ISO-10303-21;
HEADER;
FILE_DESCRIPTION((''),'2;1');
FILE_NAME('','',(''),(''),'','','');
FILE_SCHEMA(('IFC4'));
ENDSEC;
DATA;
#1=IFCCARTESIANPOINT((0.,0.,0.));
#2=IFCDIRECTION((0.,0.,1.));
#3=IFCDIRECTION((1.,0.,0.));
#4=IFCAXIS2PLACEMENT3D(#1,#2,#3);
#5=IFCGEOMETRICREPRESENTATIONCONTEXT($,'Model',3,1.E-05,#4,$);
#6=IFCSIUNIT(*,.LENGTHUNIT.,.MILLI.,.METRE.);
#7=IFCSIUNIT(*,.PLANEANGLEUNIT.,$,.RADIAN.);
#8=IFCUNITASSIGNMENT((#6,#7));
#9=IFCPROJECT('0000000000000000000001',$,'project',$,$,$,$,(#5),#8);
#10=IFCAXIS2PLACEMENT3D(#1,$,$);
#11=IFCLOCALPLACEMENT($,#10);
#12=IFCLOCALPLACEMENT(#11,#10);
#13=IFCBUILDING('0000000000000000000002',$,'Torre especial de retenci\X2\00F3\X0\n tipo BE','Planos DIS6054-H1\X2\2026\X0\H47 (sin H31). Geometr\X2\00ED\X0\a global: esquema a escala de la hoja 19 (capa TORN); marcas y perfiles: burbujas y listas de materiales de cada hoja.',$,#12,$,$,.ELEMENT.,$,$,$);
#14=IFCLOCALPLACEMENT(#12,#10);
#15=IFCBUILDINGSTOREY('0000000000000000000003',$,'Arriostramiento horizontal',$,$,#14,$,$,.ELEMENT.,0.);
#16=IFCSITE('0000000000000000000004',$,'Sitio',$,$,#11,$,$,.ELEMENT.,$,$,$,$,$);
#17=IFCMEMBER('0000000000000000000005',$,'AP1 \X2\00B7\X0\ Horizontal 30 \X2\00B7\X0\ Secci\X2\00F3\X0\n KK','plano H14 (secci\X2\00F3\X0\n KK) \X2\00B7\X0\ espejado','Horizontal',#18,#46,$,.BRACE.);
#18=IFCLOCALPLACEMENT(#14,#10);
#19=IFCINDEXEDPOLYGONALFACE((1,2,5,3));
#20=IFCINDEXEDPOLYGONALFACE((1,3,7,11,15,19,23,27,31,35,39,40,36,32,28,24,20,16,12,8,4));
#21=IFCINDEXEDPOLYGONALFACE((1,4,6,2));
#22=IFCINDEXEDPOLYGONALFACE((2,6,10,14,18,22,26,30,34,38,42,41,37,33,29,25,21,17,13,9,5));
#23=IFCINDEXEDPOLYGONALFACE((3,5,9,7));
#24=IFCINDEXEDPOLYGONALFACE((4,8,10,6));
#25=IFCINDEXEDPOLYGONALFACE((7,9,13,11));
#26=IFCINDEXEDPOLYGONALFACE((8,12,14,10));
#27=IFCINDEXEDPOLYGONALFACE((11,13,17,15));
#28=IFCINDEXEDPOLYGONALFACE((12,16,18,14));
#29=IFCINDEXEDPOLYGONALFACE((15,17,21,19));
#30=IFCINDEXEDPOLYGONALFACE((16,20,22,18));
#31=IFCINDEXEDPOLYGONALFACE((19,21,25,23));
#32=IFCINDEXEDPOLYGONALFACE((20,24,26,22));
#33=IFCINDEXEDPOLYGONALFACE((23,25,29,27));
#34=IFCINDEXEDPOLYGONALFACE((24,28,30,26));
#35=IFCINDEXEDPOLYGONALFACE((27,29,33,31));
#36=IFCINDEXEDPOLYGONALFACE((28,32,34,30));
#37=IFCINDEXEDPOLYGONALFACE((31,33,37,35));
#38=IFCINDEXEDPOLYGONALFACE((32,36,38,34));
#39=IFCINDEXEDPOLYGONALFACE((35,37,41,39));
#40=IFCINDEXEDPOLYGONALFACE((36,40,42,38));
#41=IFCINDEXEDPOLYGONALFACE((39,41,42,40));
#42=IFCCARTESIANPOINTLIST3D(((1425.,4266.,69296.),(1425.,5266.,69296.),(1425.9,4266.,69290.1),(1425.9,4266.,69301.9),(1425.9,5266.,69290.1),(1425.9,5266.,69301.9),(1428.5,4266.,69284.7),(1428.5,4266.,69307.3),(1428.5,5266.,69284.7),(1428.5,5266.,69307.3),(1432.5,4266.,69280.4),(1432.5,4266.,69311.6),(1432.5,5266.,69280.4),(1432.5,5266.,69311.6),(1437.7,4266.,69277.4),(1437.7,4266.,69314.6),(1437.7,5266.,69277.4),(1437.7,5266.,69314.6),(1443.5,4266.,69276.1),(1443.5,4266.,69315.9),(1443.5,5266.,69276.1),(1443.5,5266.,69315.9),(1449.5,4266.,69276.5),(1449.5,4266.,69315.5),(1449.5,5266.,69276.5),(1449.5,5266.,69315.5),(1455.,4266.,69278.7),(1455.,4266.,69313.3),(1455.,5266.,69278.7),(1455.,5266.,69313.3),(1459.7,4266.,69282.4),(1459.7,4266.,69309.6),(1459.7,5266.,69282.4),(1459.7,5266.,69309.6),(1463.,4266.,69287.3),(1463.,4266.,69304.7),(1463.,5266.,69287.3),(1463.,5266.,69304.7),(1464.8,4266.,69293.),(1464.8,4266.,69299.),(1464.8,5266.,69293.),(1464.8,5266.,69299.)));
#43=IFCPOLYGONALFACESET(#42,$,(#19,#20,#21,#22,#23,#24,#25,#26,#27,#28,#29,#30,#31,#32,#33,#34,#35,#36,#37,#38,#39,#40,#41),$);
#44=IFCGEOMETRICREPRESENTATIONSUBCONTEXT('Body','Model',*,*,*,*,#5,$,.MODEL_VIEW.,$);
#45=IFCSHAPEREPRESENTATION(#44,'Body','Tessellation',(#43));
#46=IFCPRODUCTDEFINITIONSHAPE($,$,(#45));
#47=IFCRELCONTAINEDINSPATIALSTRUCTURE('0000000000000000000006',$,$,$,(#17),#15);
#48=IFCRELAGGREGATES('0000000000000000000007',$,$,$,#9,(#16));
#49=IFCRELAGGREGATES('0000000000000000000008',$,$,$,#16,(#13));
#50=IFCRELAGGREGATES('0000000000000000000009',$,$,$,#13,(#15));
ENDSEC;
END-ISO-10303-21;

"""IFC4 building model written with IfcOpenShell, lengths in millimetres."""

from ifc_helpers import new_model, si_unit, frame, origin, origin_with_axes, place, context, subcontext, project, spatial, circle, extrude, element, save


model = new_model("IFC4")

# Units and contexts
model_context = context("Model", 3, precision=1e-05, world=origin_with_axes())
body_context = subcontext(model_context, "Body", "Model", "MODEL_VIEW")
ifc_project = project(units=[si_unit("LENGTHUNIT", "METRE", prefix="MILLI"), si_unit("PLANEANGLEUNIT", "RADIAN")], contexts=[model_context])

# Site, building, storey
site_placement = place(None, origin())
site = spatial("IfcSite", under=ifc_project, at=site_placement, Name="Sitio", CompositionType="ELEMENT")
building_placement = place(site_placement, origin())
building = spatial("IfcBuilding", under=site, at=building_placement, Name="Torre especial de retención tipo BE", Description="Planos DIS6054-H1…H47 (sin H31). Geometría global: esquema a escala de la hoja 19 (capa TORN); marcas y perfiles: burbujas y listas de materiales de cada hoja.", CompositionType="ELEMENT")
storey_placement = place(building_placement, origin())
storey = spatial("IfcBuildingStorey", under=building, at=storey_placement, Name="Arriostramiento horizontal", CompositionType="ELEMENT", Elevation=0.0)

# Member
for number, where, z_axis, x_axis, name in (
    (1, (1445.0, 4266.0, 69296.0), (0.0, 1.0, 0.0), (-1.0, 0.0, 0.0), "AP1 · Horizontal 30 · Sección KK"),
):
    element("IfcMember", number, at=place(storey_placement, frame(where, z_axis=z_axis, x_axis=x_axis)), inside=storey, Name=name, Description="plano H14 (sección KK) · espejado", ObjectType="Horizontal", PredefinedType="BRACE", context=body_context, shape_type="SweptSolid", body=[
        extrude(circle(Radius=20.0), None, (0.0, 0.0, 1.0), 1000.0),
    ])

save(model, "model.ifc")
